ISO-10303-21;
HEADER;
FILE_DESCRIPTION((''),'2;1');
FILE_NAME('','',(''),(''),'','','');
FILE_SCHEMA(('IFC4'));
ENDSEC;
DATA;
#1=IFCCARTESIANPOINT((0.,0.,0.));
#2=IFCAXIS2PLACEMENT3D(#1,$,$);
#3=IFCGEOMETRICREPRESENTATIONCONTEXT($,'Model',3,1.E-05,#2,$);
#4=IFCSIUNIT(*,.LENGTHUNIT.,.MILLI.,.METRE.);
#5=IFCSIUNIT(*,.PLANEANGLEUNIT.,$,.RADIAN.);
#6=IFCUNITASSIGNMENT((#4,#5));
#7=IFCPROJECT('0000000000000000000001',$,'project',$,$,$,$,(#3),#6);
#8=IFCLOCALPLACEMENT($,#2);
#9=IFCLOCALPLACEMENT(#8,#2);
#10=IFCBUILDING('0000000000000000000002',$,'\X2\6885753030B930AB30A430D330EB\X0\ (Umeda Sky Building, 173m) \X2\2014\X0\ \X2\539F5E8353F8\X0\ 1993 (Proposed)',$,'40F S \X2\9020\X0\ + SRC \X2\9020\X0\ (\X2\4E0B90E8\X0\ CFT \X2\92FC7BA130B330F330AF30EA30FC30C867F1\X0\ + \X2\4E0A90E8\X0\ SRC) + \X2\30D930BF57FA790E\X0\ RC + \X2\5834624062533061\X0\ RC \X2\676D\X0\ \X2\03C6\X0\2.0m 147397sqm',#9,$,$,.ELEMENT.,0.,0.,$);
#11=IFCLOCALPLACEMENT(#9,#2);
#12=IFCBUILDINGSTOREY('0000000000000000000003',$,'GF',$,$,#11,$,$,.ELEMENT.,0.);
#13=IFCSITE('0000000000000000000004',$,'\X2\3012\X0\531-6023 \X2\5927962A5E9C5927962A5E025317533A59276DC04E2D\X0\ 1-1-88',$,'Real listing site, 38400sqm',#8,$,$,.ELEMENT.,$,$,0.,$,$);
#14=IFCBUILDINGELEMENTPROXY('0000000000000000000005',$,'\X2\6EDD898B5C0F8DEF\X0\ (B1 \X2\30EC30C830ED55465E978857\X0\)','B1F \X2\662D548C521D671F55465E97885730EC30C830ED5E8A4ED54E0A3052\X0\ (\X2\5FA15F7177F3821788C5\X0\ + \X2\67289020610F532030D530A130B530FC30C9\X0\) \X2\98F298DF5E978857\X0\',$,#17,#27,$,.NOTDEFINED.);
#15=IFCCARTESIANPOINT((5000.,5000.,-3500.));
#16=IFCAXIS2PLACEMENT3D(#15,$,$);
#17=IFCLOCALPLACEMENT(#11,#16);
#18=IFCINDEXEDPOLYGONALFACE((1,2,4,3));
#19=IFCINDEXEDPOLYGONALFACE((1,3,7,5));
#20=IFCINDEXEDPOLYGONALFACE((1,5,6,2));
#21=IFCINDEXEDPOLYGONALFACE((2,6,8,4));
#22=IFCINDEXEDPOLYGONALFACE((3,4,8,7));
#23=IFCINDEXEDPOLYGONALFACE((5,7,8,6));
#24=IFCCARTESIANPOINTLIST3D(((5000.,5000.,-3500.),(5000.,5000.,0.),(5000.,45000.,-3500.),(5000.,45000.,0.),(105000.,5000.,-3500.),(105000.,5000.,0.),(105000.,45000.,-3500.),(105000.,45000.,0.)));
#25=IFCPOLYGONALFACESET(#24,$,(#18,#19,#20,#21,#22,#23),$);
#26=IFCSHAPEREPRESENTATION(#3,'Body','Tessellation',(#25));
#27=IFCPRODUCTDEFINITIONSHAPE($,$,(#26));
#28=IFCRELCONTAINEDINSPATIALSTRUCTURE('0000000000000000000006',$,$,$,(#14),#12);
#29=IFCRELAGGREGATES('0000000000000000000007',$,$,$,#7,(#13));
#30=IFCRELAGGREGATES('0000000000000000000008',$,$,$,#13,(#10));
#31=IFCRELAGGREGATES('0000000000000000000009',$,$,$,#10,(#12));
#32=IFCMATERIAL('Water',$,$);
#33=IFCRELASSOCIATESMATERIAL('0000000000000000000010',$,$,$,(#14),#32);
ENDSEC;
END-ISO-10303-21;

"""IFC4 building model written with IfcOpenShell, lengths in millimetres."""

from ifc_helpers import new_model, si_unit, frame, frame_2d, origin, place, context, project, spatial, rectangle, extrude, material, element, save


model = new_model("IFC4")

# Units and contexts
model_context = context("Model", 3, precision=1e-05, world=origin())
ifc_project = project(units=[si_unit("LENGTHUNIT", "METRE", prefix="MILLI"), si_unit("PLANEANGLEUNIT", "RADIAN")], contexts=[model_context])

# Site, building, storey
site_placement = place(None, origin())
site = spatial("IfcSite", under=ifc_project, at=site_placement, Name="〒531-6023 大阪府大阪市北区大淀中 1-1-88", ObjectType="Real listing site, 38400sqm", CompositionType="ELEMENT", RefElevation=0.0)
building_placement = place(site_placement, origin())
building = spatial("IfcBuilding", under=site, at=building_placement, Name="梅田スカイビル (Umeda Sky Building, 173m) — 原広司 1993 (Proposed)", ObjectType="40F S 造 + SRC 造 (下部 CFT 鋼管コンクリート柱 + 上部 SRC) + ベタ基礎 RC + 場所打ち RC 杭 φ2.0m 147397sqm", CompositionType="ELEMENT", ElevationOfRefHeight=0.0, ElevationOfTerrain=0.0)
storey_placement = place(building_placement, origin())
storey = spatial("IfcBuildingStorey", under=building, at=storey_placement, Name="GF", CompositionType="ELEMENT", Elevation=0.0)

# Building element proxy
ifc_material_1 = material(Name="Water")
proxy_placement = place(storey_placement, frame((5000.0, 5000.0, -3500.0)))
element("IfcBuildingElementProxy", 1, at=proxy_placement, inside=storey, material=ifc_material_1, Name="滝見小路 (B1 レトロ商店街)", Description="B1F 昭和初期商店街レトロ床仕上げ (御影石舗装 + 木造意匠ファサード) 飲食店街", PredefinedType="NOTDEFINED", context=model_context, shape_type="SweptSolid", body=[
    extrude(rectangle(XDim=100000.0, YDim=40000.0, at=frame_2d((50000.0, 20000.0))), frame((5000.0, 5000.0, -3500.0)), (0.0, 0.0, 1.0), 3500.0),
])

save(model, "model.ifc")
